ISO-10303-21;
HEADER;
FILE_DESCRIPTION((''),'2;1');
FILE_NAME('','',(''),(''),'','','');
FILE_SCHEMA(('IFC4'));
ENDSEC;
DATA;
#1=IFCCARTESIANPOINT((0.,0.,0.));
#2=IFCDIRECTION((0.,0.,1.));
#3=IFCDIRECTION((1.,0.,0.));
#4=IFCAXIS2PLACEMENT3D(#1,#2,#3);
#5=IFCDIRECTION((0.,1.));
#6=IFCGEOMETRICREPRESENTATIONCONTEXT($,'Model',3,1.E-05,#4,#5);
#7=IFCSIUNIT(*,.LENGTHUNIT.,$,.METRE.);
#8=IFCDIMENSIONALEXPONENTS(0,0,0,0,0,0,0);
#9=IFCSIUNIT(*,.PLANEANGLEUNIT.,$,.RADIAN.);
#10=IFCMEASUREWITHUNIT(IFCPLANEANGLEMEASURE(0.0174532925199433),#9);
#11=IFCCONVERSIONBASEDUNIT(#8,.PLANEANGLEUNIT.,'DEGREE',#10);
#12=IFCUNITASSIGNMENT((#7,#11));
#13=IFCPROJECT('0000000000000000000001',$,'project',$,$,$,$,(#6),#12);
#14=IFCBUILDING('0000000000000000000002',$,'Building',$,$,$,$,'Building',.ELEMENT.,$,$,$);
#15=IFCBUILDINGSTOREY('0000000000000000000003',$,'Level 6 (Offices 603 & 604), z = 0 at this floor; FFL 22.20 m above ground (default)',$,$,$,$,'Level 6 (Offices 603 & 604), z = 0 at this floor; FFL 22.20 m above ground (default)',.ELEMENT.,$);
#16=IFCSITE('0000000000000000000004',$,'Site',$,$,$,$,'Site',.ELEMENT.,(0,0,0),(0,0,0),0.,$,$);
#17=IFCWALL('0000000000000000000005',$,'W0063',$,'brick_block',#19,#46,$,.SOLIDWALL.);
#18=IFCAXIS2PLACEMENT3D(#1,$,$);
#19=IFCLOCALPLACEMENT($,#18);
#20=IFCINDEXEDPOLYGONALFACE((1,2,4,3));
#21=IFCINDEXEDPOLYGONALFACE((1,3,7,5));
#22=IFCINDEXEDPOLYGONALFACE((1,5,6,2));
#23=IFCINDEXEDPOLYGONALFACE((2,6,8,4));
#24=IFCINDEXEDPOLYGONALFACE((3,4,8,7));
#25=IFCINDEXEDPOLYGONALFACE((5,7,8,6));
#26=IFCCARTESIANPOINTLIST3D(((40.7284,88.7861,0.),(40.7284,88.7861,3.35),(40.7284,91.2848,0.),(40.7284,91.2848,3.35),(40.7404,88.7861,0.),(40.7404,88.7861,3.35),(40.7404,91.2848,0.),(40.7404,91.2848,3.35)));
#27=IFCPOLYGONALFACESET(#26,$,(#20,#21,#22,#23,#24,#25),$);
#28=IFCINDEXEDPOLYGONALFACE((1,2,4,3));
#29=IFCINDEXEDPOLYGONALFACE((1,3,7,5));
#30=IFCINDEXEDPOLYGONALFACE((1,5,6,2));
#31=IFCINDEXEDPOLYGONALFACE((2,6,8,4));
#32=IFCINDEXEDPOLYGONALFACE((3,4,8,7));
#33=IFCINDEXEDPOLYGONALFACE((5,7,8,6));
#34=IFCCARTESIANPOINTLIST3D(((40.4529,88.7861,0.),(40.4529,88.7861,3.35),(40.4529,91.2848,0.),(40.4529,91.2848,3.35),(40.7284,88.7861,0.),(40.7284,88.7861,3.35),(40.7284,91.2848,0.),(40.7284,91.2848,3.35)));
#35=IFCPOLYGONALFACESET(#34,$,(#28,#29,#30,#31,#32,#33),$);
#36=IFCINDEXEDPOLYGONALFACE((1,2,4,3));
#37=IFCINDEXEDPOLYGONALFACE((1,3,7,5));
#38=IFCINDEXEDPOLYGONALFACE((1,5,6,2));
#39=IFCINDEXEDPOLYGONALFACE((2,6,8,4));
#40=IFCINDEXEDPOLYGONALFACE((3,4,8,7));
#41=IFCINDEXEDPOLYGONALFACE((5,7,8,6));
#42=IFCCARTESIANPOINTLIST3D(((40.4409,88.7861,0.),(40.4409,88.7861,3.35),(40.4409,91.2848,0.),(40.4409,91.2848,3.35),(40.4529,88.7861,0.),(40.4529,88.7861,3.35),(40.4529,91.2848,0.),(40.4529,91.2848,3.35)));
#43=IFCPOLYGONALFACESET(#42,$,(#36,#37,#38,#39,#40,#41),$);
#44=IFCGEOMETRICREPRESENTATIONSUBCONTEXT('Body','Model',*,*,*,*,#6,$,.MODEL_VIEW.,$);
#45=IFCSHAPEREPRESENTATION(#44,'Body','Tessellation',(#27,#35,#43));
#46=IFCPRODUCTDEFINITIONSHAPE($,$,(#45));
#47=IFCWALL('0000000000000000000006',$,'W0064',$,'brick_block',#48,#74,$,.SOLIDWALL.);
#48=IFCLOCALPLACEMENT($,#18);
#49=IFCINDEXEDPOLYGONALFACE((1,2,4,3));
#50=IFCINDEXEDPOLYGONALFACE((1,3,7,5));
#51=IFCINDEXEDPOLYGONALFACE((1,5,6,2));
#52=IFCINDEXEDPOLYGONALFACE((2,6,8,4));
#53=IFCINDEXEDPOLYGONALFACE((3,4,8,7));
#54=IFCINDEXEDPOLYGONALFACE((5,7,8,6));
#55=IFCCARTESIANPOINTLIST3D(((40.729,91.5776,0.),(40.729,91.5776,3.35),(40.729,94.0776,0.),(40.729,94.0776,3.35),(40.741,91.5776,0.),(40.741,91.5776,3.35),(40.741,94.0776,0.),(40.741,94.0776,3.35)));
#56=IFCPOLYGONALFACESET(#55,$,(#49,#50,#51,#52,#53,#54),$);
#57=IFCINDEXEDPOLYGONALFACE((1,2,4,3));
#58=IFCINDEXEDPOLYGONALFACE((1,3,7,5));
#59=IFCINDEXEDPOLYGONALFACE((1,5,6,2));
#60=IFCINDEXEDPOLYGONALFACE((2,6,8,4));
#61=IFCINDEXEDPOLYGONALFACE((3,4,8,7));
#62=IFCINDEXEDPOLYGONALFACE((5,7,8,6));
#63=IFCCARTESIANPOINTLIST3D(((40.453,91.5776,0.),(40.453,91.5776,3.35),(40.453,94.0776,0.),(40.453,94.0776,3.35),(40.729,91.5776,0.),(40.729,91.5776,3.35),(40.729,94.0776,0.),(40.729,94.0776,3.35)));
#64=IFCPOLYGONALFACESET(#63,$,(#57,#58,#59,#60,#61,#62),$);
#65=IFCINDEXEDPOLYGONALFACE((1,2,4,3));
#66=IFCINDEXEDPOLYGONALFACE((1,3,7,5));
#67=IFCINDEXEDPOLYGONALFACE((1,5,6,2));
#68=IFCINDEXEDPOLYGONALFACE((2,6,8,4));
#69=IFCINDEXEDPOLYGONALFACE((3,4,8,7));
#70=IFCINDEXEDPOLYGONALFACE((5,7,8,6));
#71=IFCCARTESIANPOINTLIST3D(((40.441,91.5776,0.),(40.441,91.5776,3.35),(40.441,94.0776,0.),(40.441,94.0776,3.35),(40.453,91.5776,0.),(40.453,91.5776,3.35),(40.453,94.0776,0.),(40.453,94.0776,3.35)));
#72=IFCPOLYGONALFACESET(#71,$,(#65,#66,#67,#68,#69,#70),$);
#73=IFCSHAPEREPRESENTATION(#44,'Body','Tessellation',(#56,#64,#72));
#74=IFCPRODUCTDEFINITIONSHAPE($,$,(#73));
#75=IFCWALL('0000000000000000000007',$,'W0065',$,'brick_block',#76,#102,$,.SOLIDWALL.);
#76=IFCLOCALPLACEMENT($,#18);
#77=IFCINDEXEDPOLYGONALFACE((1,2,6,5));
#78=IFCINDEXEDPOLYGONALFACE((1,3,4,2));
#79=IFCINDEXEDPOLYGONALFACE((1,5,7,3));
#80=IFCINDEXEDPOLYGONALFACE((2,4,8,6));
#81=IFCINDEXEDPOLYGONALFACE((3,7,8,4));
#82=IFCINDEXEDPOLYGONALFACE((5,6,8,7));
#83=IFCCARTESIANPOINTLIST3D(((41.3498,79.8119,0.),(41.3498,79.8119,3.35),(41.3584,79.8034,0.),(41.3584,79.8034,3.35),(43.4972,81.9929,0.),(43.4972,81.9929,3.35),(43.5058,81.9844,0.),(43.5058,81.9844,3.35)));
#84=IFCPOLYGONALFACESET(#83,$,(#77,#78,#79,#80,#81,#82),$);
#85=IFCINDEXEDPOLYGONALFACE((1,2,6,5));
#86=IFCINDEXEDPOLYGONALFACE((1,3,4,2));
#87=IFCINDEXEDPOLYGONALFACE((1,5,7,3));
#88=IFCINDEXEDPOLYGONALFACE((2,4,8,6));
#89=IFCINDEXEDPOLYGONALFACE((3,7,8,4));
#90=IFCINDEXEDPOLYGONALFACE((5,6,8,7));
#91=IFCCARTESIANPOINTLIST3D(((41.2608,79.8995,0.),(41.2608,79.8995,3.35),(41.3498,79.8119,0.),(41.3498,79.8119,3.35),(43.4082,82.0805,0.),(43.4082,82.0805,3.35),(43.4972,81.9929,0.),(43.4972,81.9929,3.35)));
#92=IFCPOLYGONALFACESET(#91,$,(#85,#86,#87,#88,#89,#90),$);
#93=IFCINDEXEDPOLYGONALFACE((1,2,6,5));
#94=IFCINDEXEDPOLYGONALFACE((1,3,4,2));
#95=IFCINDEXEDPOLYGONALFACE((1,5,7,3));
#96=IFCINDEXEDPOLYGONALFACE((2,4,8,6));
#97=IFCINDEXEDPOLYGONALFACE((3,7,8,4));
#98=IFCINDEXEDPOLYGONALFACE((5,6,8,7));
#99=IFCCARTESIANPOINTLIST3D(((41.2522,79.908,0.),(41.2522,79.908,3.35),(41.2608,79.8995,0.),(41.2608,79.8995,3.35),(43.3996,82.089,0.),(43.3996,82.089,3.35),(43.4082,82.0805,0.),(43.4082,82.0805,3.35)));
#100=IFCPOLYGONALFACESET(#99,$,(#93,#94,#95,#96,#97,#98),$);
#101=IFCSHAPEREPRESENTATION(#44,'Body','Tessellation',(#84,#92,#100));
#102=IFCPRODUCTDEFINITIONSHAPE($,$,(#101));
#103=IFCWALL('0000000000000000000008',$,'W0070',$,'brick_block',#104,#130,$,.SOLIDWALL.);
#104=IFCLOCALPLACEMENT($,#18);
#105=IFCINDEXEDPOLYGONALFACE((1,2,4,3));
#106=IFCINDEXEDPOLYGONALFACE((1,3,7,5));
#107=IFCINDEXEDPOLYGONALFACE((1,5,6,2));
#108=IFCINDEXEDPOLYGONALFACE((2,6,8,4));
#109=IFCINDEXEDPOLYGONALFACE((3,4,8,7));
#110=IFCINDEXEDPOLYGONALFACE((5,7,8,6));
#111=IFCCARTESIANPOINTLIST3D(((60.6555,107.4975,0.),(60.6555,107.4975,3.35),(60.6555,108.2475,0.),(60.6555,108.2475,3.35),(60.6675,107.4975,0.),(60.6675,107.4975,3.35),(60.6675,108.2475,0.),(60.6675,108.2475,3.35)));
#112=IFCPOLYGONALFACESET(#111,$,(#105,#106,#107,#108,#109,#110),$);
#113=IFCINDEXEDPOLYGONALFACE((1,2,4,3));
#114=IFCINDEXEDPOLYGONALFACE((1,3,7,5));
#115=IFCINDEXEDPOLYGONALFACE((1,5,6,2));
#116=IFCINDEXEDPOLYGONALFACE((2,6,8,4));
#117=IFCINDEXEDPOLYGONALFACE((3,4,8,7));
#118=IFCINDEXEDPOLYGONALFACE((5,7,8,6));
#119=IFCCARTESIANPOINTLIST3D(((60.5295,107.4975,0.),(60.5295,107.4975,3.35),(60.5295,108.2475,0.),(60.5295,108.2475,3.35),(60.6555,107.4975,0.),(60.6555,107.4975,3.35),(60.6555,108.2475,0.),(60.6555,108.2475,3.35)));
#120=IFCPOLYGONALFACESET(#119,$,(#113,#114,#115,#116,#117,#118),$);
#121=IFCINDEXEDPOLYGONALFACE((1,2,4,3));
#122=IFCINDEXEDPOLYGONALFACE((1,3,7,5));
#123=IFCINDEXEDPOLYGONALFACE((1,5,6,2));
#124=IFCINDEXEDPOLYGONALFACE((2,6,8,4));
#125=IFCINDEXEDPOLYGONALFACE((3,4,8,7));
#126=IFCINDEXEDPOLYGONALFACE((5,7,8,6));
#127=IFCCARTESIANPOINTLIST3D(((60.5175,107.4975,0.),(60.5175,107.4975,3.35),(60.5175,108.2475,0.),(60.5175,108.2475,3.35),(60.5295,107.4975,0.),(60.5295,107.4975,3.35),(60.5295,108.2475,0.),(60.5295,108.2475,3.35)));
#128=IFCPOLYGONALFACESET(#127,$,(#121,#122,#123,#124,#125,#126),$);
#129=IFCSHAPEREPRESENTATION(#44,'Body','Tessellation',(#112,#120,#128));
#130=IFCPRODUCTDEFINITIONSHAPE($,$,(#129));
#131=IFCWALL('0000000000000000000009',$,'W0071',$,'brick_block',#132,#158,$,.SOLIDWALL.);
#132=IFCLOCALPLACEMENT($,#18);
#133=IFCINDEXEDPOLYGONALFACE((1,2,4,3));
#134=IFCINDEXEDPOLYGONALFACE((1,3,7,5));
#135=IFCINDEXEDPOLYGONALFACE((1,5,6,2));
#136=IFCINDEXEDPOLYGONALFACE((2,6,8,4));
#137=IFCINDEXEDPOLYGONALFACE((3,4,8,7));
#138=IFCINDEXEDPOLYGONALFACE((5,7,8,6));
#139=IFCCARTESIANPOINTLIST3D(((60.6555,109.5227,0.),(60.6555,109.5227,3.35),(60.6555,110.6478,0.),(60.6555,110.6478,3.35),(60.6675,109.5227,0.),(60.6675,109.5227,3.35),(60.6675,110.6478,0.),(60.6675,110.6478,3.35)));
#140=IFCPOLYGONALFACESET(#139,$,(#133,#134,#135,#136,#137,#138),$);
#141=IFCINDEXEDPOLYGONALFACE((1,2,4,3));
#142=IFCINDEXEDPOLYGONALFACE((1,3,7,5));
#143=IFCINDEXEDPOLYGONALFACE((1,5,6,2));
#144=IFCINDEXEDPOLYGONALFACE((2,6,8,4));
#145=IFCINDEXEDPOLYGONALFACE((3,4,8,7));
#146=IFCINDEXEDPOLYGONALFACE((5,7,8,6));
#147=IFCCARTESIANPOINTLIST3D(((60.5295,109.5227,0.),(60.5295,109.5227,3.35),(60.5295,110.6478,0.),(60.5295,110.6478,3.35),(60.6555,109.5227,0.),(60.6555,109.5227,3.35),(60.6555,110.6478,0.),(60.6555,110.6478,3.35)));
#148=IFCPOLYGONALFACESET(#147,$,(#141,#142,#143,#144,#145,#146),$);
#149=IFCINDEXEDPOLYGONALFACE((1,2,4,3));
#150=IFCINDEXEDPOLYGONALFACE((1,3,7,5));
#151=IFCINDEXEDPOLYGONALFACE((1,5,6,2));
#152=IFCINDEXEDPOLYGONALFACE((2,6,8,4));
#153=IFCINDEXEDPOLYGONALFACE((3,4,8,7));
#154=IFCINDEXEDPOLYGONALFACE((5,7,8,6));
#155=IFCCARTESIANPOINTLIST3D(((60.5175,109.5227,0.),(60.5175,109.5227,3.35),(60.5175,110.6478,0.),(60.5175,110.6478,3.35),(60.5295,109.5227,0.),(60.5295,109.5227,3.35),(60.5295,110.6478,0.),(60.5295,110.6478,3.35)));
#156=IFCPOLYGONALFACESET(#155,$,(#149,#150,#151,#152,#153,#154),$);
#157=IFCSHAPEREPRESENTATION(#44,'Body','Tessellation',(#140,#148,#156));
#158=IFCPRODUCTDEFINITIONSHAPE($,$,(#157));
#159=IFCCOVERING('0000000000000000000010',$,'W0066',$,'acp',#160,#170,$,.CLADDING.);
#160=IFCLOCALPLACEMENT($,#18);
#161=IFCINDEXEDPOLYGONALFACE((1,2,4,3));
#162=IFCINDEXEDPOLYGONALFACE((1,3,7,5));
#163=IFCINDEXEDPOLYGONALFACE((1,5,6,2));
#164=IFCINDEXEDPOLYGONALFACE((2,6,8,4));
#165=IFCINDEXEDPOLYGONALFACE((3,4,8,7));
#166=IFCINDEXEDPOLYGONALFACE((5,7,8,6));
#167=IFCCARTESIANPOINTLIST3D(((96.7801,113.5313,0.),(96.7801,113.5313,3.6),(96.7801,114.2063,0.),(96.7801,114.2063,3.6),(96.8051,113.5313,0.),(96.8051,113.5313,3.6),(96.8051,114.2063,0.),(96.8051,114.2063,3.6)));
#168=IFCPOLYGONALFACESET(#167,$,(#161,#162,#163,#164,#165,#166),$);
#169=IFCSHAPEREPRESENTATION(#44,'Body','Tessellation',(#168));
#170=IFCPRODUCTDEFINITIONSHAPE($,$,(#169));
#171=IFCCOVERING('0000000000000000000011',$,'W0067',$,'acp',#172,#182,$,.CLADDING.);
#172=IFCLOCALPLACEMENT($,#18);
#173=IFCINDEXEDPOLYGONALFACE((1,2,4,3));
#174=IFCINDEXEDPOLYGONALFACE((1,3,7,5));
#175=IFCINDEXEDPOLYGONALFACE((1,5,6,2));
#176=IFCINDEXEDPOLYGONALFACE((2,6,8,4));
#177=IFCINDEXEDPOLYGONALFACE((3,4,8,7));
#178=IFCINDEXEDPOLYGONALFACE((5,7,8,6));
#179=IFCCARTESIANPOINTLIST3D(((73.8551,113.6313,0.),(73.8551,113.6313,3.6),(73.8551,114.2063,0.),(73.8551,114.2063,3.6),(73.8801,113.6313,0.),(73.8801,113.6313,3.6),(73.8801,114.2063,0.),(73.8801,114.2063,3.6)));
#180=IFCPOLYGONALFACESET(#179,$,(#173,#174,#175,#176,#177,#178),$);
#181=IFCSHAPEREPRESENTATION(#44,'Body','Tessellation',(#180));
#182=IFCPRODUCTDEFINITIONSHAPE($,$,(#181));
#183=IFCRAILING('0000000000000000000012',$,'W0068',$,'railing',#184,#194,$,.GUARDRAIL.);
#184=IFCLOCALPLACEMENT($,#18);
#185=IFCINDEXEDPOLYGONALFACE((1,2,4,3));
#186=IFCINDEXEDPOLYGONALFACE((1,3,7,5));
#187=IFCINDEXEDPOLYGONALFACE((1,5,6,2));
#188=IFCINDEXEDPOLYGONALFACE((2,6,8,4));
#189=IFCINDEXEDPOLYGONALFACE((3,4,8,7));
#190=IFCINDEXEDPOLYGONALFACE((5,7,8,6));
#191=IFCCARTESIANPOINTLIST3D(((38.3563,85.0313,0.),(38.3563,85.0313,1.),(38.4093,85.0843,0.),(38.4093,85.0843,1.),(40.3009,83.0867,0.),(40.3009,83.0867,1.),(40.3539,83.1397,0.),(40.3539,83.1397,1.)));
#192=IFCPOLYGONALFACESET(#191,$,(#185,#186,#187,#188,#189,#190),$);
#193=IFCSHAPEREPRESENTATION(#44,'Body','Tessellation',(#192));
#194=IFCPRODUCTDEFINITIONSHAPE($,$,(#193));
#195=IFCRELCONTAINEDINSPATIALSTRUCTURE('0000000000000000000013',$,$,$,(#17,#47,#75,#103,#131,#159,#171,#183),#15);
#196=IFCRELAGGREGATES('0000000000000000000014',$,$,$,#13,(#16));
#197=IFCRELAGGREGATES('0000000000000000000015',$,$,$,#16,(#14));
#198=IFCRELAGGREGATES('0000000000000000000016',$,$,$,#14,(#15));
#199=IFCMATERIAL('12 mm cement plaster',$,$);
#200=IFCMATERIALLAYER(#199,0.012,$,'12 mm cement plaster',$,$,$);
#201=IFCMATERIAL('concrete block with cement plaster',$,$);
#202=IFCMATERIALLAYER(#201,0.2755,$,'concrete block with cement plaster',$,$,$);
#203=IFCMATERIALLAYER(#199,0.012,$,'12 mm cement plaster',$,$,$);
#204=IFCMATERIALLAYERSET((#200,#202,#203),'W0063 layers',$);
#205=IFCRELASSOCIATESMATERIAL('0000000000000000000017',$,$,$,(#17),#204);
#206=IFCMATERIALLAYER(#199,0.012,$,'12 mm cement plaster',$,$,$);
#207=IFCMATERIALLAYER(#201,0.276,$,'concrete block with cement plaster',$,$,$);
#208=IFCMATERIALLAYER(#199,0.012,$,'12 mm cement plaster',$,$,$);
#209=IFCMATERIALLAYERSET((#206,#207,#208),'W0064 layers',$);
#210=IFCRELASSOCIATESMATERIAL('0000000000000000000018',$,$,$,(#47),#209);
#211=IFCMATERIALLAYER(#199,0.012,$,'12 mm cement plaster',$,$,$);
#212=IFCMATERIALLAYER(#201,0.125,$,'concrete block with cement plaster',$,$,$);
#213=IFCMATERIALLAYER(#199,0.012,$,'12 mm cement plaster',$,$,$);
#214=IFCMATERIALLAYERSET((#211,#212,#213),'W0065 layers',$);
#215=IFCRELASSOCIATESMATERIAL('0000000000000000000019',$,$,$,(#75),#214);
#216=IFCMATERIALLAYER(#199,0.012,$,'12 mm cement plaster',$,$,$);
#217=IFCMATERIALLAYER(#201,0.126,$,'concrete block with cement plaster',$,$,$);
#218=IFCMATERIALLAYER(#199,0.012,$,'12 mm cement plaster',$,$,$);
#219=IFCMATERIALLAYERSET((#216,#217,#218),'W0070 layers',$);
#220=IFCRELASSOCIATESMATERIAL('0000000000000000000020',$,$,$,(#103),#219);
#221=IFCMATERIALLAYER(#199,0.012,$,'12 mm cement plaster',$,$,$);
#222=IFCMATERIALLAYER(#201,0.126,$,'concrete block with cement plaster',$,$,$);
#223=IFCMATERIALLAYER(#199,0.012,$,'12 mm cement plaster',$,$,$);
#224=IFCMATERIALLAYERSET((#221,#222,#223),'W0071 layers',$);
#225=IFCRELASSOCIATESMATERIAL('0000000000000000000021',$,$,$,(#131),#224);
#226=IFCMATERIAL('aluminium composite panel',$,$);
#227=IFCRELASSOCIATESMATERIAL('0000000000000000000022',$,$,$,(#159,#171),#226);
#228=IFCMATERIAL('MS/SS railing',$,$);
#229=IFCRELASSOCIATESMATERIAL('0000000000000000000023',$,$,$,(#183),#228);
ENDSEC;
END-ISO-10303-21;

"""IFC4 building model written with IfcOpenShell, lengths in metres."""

from ifc_helpers import new_model, entity, si_unit, converted_unit, direction, frame, frame_2d, origin_with_axes, place, context, subcontext, project, spatial, rectangle, extrude, material, layer, layer_set, layer_usage, element, save


model = new_model("IFC4")

# Units and contexts
model_context = context("Model", 3, precision=1e-05, world=origin_with_axes(), true_north=direction((0.0, 1.0)))
body_context = subcontext(model_context, "Body", "Model", "MODEL_VIEW")
ifc_project = project(units=[si_unit("LENGTHUNIT", "METRE"), converted_unit("PLANEANGLEUNIT", "DEGREE", entity("IfcPlaneAngleMeasure", 0.0174532925199433), si_unit("PLANEANGLEUNIT", "RADIAN"), dimensions=[0, 0, 0, 0, 0, 0, 0])], contexts=[model_context])

# Site, building, storey
site = spatial("IfcSite", under=ifc_project, Name="Site", LongName="Site", CompositionType="ELEMENT", RefLatitude=(0, 0, 0), RefLongitude=(0, 0, 0), RefElevation=0.0)
building = spatial("IfcBuilding", under=site, Name="Building", LongName="Building", CompositionType="ELEMENT")
storey = spatial("IfcBuildingStorey", under=building, Name="Level 6 (Offices 603 & 604), z = 0 at this floor; FFL 22.20 m above ground (default)", LongName="Level 6 (Offices 603 & 604), z = 0 at this floor; FFL 22.20 m above ground (default)", CompositionType="ELEMENT")

# Walls
ifc_material_1 = material(Name="12 mm cement plaster")
ifc_material_2 = material(Name="concrete block with cement plaster")
placement = place(None, origin_with_axes())
ifc_layer_1 = layer(ifc_material_1, 0.012, Name="12 mm cement plaster")
ifc_layer_2 = layer(ifc_material_2, 0.2755, Name="concrete block with cement plaster")
ifc_layer_3 = layer(ifc_material_1, 0.012, Name="12 mm cement plaster")
ifc_layer_set_1 = layer_set([ifc_layer_1, ifc_layer_2, ifc_layer_3], Name="W0063 layers")
ifc_layer_usage_1 = layer_usage(ifc_layer_set_1, "AXIS2", "POSITIVE", -0.1497)
element("IfcWall", 1, at=placement, inside=storey, material=ifc_layer_usage_1, Name="W0063", ObjectType="brick_block", PredefinedType="SOLIDWALL", context=body_context, shape_type="SweptSolid", body=[
    extrude(rectangle(XDim=2.4987, YDim=0.012, at=frame_2d((0.0, 0.0), x_axis=(0.0, 1.0))), frame((40.7345, 90.0354, 0.0), z_axis=(0.0, 0.0, 1.0), x_axis=(1.0, 0.0, 0.0)), (0.0, 0.0, 1.0), 3.35),
    extrude(rectangle(XDim=2.4987, YDim=0.2755, at=frame_2d((-0.1438, 0.0), x_axis=(0.0, 1.0))), frame((40.7345, 90.0354, 0.0), z_axis=(0.0, 0.0, 1.0), x_axis=(1.0, 0.0, 0.0)), (0.0, 0.0, 1.0), 3.35),
    extrude(rectangle(XDim=2.4987, YDim=0.012, at=frame_2d((-0.2875, 0.0), x_axis=(0.0, 1.0))), frame((40.7345, 90.0354, 0.0), z_axis=(0.0, 0.0, 1.0), x_axis=(1.0, 0.0, 0.0)), (0.0, 0.0, 1.0), 3.35),
])
ifc_layer_4 = layer(ifc_material_1, 0.012, Name="12 mm cement plaster")
ifc_layer_5 = layer(ifc_material_2, 0.276, Name="concrete block with cement plaster")
ifc_layer_6 = layer(ifc_material_1, 0.012, Name="12 mm cement plaster")
ifc_layer_set_2 = layer_set([ifc_layer_4, ifc_layer_5, ifc_layer_6], Name="W0064 layers")
ifc_layer_usage_2 = layer_usage(ifc_layer_set_2, "AXIS2", "POSITIVE", -0.15)
element("IfcWall", 2, at=placement, inside=storey, material=ifc_layer_usage_2, Name="W0064", ObjectType="brick_block", PredefinedType="SOLIDWALL", context=body_context, shape_type="SweptSolid", body=[
    extrude(rectangle(XDim=2.5, YDim=0.012, at=frame_2d((0.0, 0.0), x_axis=(0.0, 1.0))), frame((40.735, 92.8276, 0.0), z_axis=(0.0, 0.0, 1.0), x_axis=(1.0, 0.0, 0.0)), (0.0, 0.0, 1.0), 3.35),
    extrude(rectangle(XDim=2.5, YDim=0.276, at=frame_2d((-0.144, 0.0), x_axis=(0.0, 1.0))), frame((40.735, 92.8276, 0.0), z_axis=(0.0, 0.0, 1.0), x_axis=(1.0, 0.0, 0.0)), (0.0, 0.0, 1.0), 3.35),
    extrude(rectangle(XDim=2.5, YDim=0.012, at=frame_2d((-0.288, 0.0), x_axis=(0.0, 1.0))), frame((40.735, 92.8276, 0.0), z_axis=(0.0, 0.0, 1.0), x_axis=(1.0, 0.0, 0.0)), (0.0, 0.0, 1.0), 3.35),
])
ifc_layer_7 = layer(ifc_material_1, 0.012, Name="12 mm cement plaster")
ifc_layer_8 = layer(ifc_material_2, 0.125, Name="concrete block with cement plaster")
ifc_layer_9 = layer(ifc_material_1, 0.012, Name="12 mm cement plaster")
ifc_layer_set_3 = layer_set([ifc_layer_7, ifc_layer_8, ifc_layer_9], Name="W0065 layers")
ifc_layer_usage_3 = layer_usage(ifc_layer_set_3, "AXIS2", "POSITIVE", -0.0745)
element("IfcWall", 3, at=placement, inside=storey, material=ifc_layer_usage_3, Name="W0065", ObjectType="brick_block", PredefinedType="SOLIDWALL", context=body_context, shape_type="SweptSolid", body=[
    extrude(rectangle(XDim=3.0607, YDim=0.012, at=frame_2d((0.0, 0.0), x_axis=(0.701597, 0.712574))), frame((42.4278, 80.8981, 0.0), z_axis=(0.0, 0.0, 1.0), x_axis=(1.0, 0.0, 0.0)), (0.0, 0.0, 1.0), 3.35),
    extrude(rectangle(XDim=3.0607, YDim=0.125, at=frame_2d((-0.0488, 0.0481), x_axis=(0.701597, 0.712574))), frame((42.4278, 80.8981, 0.0), z_axis=(0.0, 0.0, 1.0), x_axis=(1.0, 0.0, 0.0)), (0.0, 0.0, 1.0), 3.35),
    extrude(rectangle(XDim=3.0607, YDim=0.012, at=frame_2d((-0.0976, 0.0961), x_axis=(0.701597, 0.712574))), frame((42.4278, 80.8981, 0.0), z_axis=(0.0, 0.0, 1.0), x_axis=(1.0, 0.0, 0.0)), (0.0, 0.0, 1.0), 3.35),
])
ifc_layer_10 = layer(ifc_material_1, 0.012, Name="12 mm cement plaster")
ifc_layer_11 = layer(ifc_material_2, 0.126, Name="concrete block with cement plaster")
ifc_layer_12 = layer(ifc_material_1, 0.012, Name="12 mm cement plaster")
ifc_layer_set_4 = layer_set([ifc_layer_10, ifc_layer_11, ifc_layer_12], Name="W0070 layers")
ifc_layer_usage_4 = layer_usage(ifc_layer_set_4, "AXIS2", "POSITIVE", -0.075)
element("IfcWall", 4, at=placement, inside=storey, material=ifc_layer_usage_4, Name="W0070", ObjectType="brick_block", PredefinedType="SOLIDWALL", context=body_context, shape_type="SweptSolid", body=[
    extrude(rectangle(XDim=0.75, YDim=0.012, at=frame_2d((0.0, 0.0), x_axis=(0.0, 1.0))), frame((60.6615, 107.8725, 0.0), z_axis=(0.0, 0.0, 1.0), x_axis=(1.0, 0.0, 0.0)), (0.0, 0.0, 1.0), 3.35),
    extrude(rectangle(XDim=0.75, YDim=0.126, at=frame_2d((-0.069, 0.0), x_axis=(0.0, 1.0))), frame((60.6615, 107.8725, 0.0), z_axis=(0.0, 0.0, 1.0), x_axis=(1.0, 0.0, 0.0)), (0.0, 0.0, 1.0), 3.35),
    extrude(rectangle(XDim=0.75, YDim=0.012, at=frame_2d((-0.138, 0.0), x_axis=(0.0, 1.0))), frame((60.6615, 107.8725, 0.0), z_axis=(0.0, 0.0, 1.0), x_axis=(1.0, 0.0, 0.0)), (0.0, 0.0, 1.0), 3.35),
])
ifc_layer_13 = layer(ifc_material_1, 0.012, Name="12 mm cement plaster")
ifc_layer_14 = layer(ifc_material_2, 0.126, Name="concrete block with cement plaster")
ifc_layer_15 = layer(ifc_material_1, 0.012, Name="12 mm cement plaster")
ifc_layer_set_5 = layer_set([ifc_layer_13, ifc_layer_14, ifc_layer_15], Name="W0071 layers")
ifc_layer_usage_5 = layer_usage(ifc_layer_set_5, "AXIS2", "POSITIVE", -0.075)
element("IfcWall", 5, at=placement, inside=storey, material=ifc_layer_usage_5, Name="W0071", ObjectType="brick_block", PredefinedType="SOLIDWALL", context=body_context, shape_type="SweptSolid", body=[
    extrude(rectangle(XDim=1.1251, YDim=0.012, at=frame_2d((0.0, 0.0), x_axis=(0.0, 1.0))), frame((60.6615, 110.0853, 0.0), z_axis=(0.0, 0.0, 1.0), x_axis=(1.0, 0.0, 0.0)), (0.0, 0.0, 1.0), 3.35),
    extrude(rectangle(XDim=1.1251, YDim=0.126, at=frame_2d((-0.069, 0.0), x_axis=(0.0, 1.0))), frame((60.6615, 110.0853, 0.0), z_axis=(0.0, 0.0, 1.0), x_axis=(1.0, 0.0, 0.0)), (0.0, 0.0, 1.0), 3.35),
    extrude(rectangle(XDim=1.1251, YDim=0.012, at=frame_2d((-0.138, 0.0), x_axis=(0.0, 1.0))), frame((60.6615, 110.0853, 0.0), z_axis=(0.0, 0.0, 1.0), x_axis=(1.0, 0.0, 0.0)), (0.0, 0.0, 1.0), 3.35),
])

# Coverings
ifc_material_3 = material(Name="aluminium composite panel")
element("IfcCovering", 6, at=placement, inside=storey, material=ifc_material_3, Name="W0066", ObjectType="acp", PredefinedType="CLADDING", context=body_context, shape_type="SweptSolid", body=[
    extrude(rectangle(XDim=0.675, YDim=0.025, at=frame_2d((0.0, 0.0), x_axis=(0.0, 1.0))), frame((96.7926, 113.8688, 0.0), z_axis=(0.0, 0.0, 1.0), x_axis=(1.0, 0.0, 0.0)), (0.0, 0.0, 1.0), 3.6),
])
element("IfcCovering", 7, at=placement, inside=storey, material=ifc_material_3, Name="W0067", ObjectType="acp", PredefinedType="CLADDING", context=body_context, shape_type="SweptSolid", body=[
    extrude(rectangle(XDim=0.575, YDim=0.025, at=frame_2d((0.0, 0.0), x_axis=(0.0, 1.0))), frame((73.8676, 113.9188, 0.0), z_axis=(0.0, 0.0, 1.0), x_axis=(1.0, 0.0, 0.0)), (0.0, 0.0, 1.0), 3.6),
])

# Railing
ifc_material_4 = material(Name="MS/SS railing")
element("IfcRailing", 8, at=placement, inside=storey, material=ifc_material_4, Name="W0068", ObjectType="railing", PredefinedType="GUARDRAIL", context=body_context, shape_type="SweptSolid", body=[
    extrude(rectangle(XDim=2.7501, YDim=0.075, at=frame_2d((0.0, 0.0), x_axis=(0.707107, -0.707107))), frame((39.3551, 84.0855, 0.0), z_axis=(0.0, 0.0, 1.0), x_axis=(1.0, 0.0, 0.0)), (0.0, 0.0, 1.0), 1.0),
])

save(model, "model.ifc")
